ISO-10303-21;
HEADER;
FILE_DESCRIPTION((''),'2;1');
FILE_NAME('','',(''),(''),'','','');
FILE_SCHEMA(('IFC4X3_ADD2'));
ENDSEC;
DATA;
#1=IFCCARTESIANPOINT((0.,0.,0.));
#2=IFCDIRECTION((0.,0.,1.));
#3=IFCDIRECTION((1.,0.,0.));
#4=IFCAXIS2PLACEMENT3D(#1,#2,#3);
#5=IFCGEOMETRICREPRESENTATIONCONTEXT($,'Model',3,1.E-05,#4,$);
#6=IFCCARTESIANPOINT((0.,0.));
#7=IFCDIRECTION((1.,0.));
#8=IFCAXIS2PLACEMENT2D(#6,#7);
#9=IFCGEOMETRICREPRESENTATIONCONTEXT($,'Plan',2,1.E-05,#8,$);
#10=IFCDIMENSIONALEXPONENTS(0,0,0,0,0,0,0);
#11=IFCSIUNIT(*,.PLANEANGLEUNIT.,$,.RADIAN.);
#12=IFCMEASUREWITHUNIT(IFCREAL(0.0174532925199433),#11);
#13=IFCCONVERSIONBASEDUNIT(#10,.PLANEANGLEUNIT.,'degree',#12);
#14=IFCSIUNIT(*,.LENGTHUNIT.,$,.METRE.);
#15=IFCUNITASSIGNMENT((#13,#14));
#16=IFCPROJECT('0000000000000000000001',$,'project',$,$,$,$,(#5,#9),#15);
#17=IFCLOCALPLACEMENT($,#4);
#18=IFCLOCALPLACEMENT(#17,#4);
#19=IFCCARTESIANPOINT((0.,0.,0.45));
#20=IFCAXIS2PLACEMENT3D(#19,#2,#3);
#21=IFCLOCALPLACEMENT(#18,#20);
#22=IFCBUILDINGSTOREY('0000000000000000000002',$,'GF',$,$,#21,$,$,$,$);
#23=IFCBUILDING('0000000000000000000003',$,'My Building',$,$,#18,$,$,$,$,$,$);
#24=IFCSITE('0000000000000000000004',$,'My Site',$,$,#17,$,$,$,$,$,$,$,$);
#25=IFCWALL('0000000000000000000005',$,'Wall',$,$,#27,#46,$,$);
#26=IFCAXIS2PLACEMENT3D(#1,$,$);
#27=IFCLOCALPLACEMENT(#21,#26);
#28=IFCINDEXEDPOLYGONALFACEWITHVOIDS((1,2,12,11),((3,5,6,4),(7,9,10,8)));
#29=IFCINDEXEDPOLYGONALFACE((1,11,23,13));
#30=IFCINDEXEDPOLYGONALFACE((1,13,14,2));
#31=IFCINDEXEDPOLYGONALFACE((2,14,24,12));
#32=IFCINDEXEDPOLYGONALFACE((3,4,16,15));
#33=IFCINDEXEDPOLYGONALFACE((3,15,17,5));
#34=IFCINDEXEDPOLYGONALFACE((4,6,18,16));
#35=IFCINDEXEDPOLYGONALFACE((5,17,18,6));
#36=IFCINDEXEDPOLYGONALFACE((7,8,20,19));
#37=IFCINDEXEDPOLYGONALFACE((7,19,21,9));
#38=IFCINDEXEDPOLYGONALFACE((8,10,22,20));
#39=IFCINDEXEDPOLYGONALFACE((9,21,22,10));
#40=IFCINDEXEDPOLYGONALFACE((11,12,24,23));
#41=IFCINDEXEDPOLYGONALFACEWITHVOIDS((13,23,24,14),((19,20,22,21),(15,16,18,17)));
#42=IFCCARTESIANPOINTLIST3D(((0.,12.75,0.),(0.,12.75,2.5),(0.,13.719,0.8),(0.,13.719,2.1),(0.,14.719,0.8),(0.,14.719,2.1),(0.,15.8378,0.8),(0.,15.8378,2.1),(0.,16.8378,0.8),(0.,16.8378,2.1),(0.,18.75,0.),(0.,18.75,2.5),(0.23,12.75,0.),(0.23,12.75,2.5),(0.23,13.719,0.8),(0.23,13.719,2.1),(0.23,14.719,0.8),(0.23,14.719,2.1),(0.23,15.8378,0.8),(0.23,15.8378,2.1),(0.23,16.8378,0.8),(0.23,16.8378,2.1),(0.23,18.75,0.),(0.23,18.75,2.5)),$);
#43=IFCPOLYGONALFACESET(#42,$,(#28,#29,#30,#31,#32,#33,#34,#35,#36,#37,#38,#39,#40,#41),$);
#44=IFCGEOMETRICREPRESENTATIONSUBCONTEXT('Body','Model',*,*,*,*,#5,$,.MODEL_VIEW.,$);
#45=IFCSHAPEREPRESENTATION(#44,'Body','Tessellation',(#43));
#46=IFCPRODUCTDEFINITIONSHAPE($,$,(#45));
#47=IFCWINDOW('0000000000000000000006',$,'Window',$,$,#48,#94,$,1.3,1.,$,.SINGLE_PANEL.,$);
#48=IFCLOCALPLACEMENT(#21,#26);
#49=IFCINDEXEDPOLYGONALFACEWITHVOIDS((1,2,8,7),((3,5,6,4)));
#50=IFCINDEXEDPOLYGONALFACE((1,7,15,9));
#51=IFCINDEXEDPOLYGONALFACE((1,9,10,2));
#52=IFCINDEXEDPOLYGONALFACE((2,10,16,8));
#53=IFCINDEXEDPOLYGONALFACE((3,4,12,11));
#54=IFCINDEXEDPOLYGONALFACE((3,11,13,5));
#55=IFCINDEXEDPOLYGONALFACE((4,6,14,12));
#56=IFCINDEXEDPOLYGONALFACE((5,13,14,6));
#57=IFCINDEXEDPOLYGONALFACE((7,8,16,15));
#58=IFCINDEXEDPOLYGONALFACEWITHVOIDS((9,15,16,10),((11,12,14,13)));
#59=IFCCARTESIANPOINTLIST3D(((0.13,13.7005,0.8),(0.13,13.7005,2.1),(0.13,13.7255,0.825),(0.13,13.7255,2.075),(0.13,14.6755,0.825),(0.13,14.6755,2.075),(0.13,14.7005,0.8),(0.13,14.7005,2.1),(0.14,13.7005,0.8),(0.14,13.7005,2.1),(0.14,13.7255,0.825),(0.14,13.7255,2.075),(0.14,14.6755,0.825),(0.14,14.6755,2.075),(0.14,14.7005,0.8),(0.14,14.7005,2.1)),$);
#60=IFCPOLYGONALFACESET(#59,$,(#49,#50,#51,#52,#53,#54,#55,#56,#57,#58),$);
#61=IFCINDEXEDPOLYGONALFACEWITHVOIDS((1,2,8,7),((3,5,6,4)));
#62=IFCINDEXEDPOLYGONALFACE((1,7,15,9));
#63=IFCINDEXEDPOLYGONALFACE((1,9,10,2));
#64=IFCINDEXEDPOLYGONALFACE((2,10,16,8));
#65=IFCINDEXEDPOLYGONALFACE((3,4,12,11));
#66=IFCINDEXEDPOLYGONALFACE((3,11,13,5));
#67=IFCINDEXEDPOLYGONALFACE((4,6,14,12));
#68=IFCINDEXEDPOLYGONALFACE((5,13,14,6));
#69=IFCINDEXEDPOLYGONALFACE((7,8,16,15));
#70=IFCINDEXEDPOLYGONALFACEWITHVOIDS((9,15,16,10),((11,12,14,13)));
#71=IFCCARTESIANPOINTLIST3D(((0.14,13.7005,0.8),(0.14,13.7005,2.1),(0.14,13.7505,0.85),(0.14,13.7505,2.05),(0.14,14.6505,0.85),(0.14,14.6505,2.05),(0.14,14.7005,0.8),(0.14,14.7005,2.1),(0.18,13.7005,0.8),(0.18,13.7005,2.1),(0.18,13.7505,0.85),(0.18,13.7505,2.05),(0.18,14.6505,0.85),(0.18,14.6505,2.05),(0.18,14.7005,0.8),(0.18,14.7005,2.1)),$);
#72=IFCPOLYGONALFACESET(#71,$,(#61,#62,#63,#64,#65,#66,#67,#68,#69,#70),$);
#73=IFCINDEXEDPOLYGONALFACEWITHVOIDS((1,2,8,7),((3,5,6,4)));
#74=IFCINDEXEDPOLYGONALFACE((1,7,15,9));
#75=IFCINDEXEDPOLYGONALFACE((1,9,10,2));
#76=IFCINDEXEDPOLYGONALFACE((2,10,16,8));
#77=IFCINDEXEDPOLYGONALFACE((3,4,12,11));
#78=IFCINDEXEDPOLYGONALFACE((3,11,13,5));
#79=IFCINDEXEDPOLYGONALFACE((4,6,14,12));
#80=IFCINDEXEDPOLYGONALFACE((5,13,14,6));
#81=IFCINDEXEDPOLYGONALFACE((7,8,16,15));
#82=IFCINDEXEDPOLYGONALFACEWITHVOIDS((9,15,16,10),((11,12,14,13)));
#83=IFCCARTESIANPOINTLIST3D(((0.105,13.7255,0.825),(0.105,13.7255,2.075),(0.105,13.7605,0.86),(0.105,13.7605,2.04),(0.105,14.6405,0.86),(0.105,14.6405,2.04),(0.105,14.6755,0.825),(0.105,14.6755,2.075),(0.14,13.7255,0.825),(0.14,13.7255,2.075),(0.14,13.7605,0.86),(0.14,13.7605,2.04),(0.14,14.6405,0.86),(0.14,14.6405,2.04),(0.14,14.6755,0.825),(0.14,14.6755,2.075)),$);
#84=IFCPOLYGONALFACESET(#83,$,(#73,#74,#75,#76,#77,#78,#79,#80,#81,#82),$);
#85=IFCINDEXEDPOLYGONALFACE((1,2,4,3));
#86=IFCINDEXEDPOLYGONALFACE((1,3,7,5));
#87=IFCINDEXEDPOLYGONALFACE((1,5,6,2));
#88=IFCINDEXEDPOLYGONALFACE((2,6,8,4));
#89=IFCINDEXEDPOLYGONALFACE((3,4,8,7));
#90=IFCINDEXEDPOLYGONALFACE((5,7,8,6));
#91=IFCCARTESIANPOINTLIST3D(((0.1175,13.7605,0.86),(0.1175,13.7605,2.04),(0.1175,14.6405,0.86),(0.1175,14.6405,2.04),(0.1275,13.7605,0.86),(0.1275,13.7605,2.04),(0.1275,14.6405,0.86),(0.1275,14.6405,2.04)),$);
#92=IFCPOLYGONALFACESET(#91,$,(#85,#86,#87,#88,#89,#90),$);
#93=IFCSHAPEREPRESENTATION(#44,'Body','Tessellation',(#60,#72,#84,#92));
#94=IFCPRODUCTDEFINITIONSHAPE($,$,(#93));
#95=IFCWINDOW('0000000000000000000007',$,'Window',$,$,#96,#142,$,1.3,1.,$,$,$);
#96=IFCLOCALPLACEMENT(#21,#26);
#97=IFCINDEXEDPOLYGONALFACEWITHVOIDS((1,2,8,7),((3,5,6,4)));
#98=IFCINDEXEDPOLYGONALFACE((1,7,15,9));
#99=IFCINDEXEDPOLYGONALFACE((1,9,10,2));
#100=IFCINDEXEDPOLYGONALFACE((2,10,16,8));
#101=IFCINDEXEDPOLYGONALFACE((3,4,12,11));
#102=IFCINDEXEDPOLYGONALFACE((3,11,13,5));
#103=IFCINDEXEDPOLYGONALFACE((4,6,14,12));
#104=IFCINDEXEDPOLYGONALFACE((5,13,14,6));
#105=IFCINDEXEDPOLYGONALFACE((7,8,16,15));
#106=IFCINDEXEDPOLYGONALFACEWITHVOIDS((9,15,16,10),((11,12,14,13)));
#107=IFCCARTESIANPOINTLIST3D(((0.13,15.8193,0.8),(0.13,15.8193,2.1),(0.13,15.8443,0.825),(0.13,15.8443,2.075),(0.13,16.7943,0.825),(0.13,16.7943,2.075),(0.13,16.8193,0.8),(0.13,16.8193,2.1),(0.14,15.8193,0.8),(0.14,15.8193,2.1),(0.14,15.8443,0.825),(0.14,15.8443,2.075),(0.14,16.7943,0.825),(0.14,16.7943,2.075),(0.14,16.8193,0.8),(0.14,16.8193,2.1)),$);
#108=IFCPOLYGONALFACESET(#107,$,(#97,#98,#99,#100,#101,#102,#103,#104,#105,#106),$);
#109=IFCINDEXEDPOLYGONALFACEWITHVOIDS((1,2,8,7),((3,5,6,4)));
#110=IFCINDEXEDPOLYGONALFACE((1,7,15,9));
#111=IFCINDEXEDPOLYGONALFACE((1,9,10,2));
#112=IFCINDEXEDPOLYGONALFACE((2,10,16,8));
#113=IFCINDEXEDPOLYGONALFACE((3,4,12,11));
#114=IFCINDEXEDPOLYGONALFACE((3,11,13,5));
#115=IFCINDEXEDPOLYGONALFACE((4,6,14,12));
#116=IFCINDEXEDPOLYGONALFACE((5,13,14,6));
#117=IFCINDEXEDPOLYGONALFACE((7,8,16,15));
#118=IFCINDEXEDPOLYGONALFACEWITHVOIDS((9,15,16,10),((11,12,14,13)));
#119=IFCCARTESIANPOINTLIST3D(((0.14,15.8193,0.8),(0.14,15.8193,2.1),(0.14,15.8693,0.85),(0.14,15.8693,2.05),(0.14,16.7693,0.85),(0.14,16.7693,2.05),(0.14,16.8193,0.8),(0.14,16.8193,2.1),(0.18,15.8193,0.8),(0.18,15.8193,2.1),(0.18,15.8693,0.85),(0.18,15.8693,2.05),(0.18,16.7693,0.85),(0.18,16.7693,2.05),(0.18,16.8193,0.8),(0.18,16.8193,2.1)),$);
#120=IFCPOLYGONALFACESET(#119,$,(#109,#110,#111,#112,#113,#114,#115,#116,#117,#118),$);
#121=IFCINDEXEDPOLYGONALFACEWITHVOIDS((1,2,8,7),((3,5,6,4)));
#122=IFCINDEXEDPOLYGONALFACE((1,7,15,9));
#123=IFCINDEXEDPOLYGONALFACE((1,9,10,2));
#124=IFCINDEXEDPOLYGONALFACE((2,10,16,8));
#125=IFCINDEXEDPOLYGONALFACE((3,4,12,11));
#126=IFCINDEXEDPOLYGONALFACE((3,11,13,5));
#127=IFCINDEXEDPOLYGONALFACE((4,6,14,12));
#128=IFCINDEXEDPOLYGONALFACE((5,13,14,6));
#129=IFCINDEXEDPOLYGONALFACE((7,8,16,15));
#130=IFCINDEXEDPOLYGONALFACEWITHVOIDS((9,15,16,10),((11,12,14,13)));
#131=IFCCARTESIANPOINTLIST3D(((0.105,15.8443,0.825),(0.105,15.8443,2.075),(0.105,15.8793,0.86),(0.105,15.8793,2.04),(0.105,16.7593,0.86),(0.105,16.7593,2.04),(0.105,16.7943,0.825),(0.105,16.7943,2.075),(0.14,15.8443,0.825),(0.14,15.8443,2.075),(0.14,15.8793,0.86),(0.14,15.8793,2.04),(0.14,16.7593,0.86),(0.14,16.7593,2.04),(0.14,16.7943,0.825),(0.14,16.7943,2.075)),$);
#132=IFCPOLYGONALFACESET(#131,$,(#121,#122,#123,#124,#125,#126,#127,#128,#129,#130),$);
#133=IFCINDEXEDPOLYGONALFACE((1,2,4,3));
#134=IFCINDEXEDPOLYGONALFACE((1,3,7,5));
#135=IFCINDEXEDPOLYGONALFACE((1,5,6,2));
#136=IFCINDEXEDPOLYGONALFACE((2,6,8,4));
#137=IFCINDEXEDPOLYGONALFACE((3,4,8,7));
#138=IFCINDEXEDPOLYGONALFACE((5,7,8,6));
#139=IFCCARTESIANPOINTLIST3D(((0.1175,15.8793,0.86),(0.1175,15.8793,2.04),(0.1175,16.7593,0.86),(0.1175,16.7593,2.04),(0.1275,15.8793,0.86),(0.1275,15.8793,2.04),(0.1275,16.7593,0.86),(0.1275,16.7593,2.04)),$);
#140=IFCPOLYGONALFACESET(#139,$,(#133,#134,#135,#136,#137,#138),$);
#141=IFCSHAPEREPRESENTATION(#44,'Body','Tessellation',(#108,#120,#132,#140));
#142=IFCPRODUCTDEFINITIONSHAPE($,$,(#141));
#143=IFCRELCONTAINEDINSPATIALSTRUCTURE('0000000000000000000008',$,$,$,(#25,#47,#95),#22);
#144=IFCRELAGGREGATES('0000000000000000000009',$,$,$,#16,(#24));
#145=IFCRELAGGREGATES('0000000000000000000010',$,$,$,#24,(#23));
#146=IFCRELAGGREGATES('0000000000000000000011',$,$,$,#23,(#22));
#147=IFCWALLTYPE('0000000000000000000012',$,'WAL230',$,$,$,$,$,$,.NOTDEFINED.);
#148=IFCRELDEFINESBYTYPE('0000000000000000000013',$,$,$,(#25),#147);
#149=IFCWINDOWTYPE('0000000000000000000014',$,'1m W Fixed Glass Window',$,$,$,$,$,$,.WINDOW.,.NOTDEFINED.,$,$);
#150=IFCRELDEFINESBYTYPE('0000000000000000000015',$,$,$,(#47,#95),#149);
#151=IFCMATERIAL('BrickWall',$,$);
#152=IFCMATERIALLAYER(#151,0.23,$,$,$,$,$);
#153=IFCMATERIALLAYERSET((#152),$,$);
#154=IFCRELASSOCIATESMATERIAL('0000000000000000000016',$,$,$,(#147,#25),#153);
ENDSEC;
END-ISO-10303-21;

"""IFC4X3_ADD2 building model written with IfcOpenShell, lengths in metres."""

from ifc_helpers import new_model, entity, si_unit, converted_unit, frame, origin_with_axes, origin_2d_with_axis, place, context, subcontext, project, spatial, line, indexed_curve, outline, extrude, shape, source, transform, mapped, material, layer, layer_set, layer_usage, type_object, type_shapes, element, fill, save


model = new_model("IFC4X3_ADD2")

# Units and contexts
model_context = context("Model", 3, precision=1e-05, world=origin_with_axes())
plan_context = context("Plan", 2, precision=1e-05, world=origin_2d_with_axis())
body_context_1 = subcontext(model_context, "Body", "Model", "MODEL_VIEW")
body_context_2 = subcontext(plan_context, "Body", "Plan", "PLAN_VIEW")
ifc_project = project(units=[converted_unit("PLANEANGLEUNIT", "degree", entity("IfcReal", 0.0174532925199433), si_unit("PLANEANGLEUNIT", "RADIAN"), dimensions=[0, 0, 0, 0, 0, 0, 0]), si_unit("LENGTHUNIT", "METRE")], contexts=[model_context, plan_context])

# Site, building, storey
site_placement = place(None, origin_with_axes())
site = spatial("IfcSite", under=ifc_project, at=site_placement, Name="My Site")
building_placement = place(site_placement, origin_with_axes())
building = spatial("IfcBuilding", under=site, at=building_placement, Name="My Building")
storey_placement = place(building_placement, frame((0.0, 0.0, 0.45), z_axis=(0.0, 0.0, 1.0), x_axis=(1.0, 0.0, 0.0)))
storey = spatial("IfcBuildingStorey", under=building, at=storey_placement, Name="GF")

# Shared definitions
ifc_material_1 = material(Name="BrickWall")
ifc_layer_1 = layer(ifc_material_1, 0.23)
ifc_layer_set_1 = layer_set([ifc_layer_1])
wall_type_1 = type_object("IfcWallType", Name="WAL230", PredefinedType="NOTDEFINED", material=ifc_layer_set_1)
shared_shape_1 = source(origin_with_axes(), body_context_1, "Body", "SweptSolid", [
    extrude(outline(indexed_curve([(0.0, 0.0), (1.0, 0.0), (1.0, 1.3), (0.0, 1.3)], segments=[line(1, 2, 3, 4, 1)])), frame((0.0, -0.6, 0.0), z_axis=(0.0, -1.0, 0.0), x_axis=(1.0, 0.0, 0.0)), (0.0, 0.0, -1.0), 1.2),
])
window_type_1 = type_object("IfcWindowType", Name="1m W Fixed Glass Window", PartitioningType="NOTDEFINED", PredefinedType="WINDOW")
shared_shape_2 = source(origin_with_axes(), body_context_1, "Body", "SweptSolid", [
    extrude(outline(indexed_curve([(0.0, 0.0), (1.0, 0.0), (1.0, 1.3), (0.0, 1.3)], segments=[line(1, 2, 3, 4, 1)]), holes=[indexed_curve([(0.025, 0.025), (0.975, 0.025), (0.975, 1.275), (0.025, 1.275)], segments=[line(1, 2, 3, 4, 1)])]), frame((0.0, 0.09, 0.0), z_axis=(0.0, -1.0, 0.0), x_axis=(1.0, 0.0, 0.0)), (0.0, 0.0, -1.0), 0.01),
    extrude(outline(indexed_curve([(0.0, 0.0), (1.0, 0.0), (1.0, 1.3), (0.0, 1.3)], segments=[line(1, 2, 3, 4, 1)]), holes=[indexed_curve([(0.05, 0.05), (0.95, 0.05), (0.95, 1.25), (0.05, 1.25)], segments=[line(1, 2, 3, 4, 1)])]), frame((0.0, 0.05, 0.0), z_axis=(0.0, -1.0, 0.0), x_axis=(1.0, 0.0, 0.0)), (0.0, 0.0, -1.0), 0.04),
    extrude(outline(indexed_curve([(0.0, 0.0), (0.95, 0.0), (0.95, 1.25), (0.0, 1.25)], segments=[line(1, 2, 3, 4, 1)]), holes=[indexed_curve([(0.035, 0.035), (0.915, 0.035), (0.915, 1.215), (0.035, 1.215)], segments=[line(1, 2, 3, 4, 1)])]), frame((0.025, 0.09, 0.025), z_axis=(0.0, -1.0, 0.0), x_axis=(1.0, 0.0, 0.0)), (0.0, 0.0, -1.0), 0.035),
    extrude(outline(indexed_curve([(0.035, 0.035), (0.915, 0.035), (0.915, 1.215), (0.035, 1.215)], segments=[line(1, 2, 3, 4, 1)])), frame((0.025, 0.1025, 0.025), z_axis=(0.0, -1.0, 0.0), x_axis=(1.0, 0.0, 0.0)), (0.0, 0.0, -1.0), 0.01),
])
shared_shape_3 = source(origin_with_axes(), body_context_2, "Body", "Curve2D", [
    entity("IfcIndexedPolyCurve", entity("IfcCartesianPointList2D", [[0.05, 0.05], [0.95, 0.05]])),
    entity("IfcIndexedPolyCurve", entity("IfcCartesianPointList2D", [[0.0, 0.1], [0.025, 0.1], [0.025, 0.09], [0.05, 0.09], [0.05, 0.05], [0.0, 0.05]]), [entity("IfcLineIndex", [1, 2, 3, 4, 5, 6, 1])]),
    entity("IfcIndexedPolyCurve", entity("IfcCartesianPointList2D", [[1.0, 0.1], [0.975, 0.1], [0.975, 0.09], [0.95, 0.09], [0.95, 0.05], [1.0, 0.05]]), [entity("IfcLineIndex", [1, 2, 3, 4, 5, 6, 1])]),
    entity("IfcIndexedPolyCurve", entity("IfcCartesianPointList2D", [[0.025, 0.09], [0.06, 0.09], [0.06, 0.125], [0.025, 0.125]]), [entity("IfcLineIndex", [1, 2, 3, 4, 1])]),
    entity("IfcIndexedPolyCurve", entity("IfcCartesianPointList2D", [[0.975, 0.09], [0.94, 0.09], [0.94, 0.125], [0.975, 0.125]]), [entity("IfcLineIndex", [1, 2, 3, 4, 1])]),
    entity("IfcIndexedPolyCurve", entity("IfcCartesianPointList2D", [[0.06, 0.09], [0.94, 0.09]])),
    entity("IfcIndexedPolyCurve", entity("IfcCartesianPointList2D", [[0.06, 0.125], [0.94, 0.125]])),
    entity("IfcIndexedPolyCurve", entity("IfcCartesianPointList2D", [[0.06, 0.1075], [0.94, 0.1075]])),
])
type_shapes(window_type_1, [shared_shape_2, shared_shape_3])

# Wall, openings, windows
ifc_layer_usage_1 = layer_usage(ifc_layer_set_1, "AXIS2", "POSITIVE", 0.0)
wall_1_placement = place(storey_placement, frame((0.23, 12.75, 0.0), z_axis=(0.0, 0.0, 1.0), x_axis=(0.0, 1.0, 0.0)))
wall_1 = element("IfcWall", 1, at=wall_1_placement, inside=storey, type_object=wall_type_1, material=ifc_layer_usage_1, Name="Wall", context=body_context_1, shape_type="SweptSolid", body=[
    extrude(outline(indexed_curve([(0.0, 0.0), (0.0, 0.23), (6.0, 0.23), (6.0, 0.0), (0.0, 0.0)], self_intersect=False)), origin_with_axes(), (0.0, 0.0, 1.0), 2.5),
])
opening_1_placement = place(wall_1_placement, frame((0.969, 0.0, 0.8), z_axis=(0.0, 0.0, 1.0), x_axis=(1.0, 0.0, 0.0)))
opening_1 = element("IfcOpeningElement", 2, at=opening_1_placement, cuts=wall_1, PredefinedType="OPENING", context=body_context_1, shape_type="MappedRepresentation", body=[
    mapped(shared_shape_1, transform((0.0, 0.0, 0.0), x_axis=(1.0, 0.0, 0.0), y_axis=(0.0, 1.0, 0.0), z_axis=(0.0, 0.0, 1.0), scale=1.0)),
])
opening_2_placement = place(wall_1_placement, frame((3.0878, 0.0, 0.8), z_axis=(0.0, 0.0, 1.0), x_axis=(1.0, 0.0, 0.0)))
opening_2 = element("IfcOpeningElement", 3, at=opening_2_placement, cuts=wall_1, PredefinedType="OPENING", context=body_context_1, shape_type="MappedRepresentation", body=[
    mapped(shared_shape_1, transform((0.0, 0.0, 0.0), x_axis=(1.0, 0.0, 0.0), y_axis=(0.0, 1.0, 0.0), z_axis=(0.0, 0.0, 1.0), scale=1.0)),
])
window_1_placement = place(opening_1_placement, frame((-0.0184, 0.0, 0.0), z_axis=(0.0, 0.0, 1.0), x_axis=(1.0, 0.0, 0.0)))
window_1 = element("IfcWindow", 4, at=window_1_placement, inside=storey, type_object=window_type_1, Name="Window", OverallHeight=1.3, OverallWidth=1.0, PartitioningType="SINGLE_PANEL", shapes=[
    shape(body_context_1, "Body", "MappedRepresentation", [mapped(shared_shape_2, transform((0.0, 0.0, 0.0), x_axis=(1.0, 0.0, 0.0), y_axis=(0.0, 1.0, 0.0), z_axis=(0.0, 0.0, 1.0), scale=1.0))]),
    shape(body_context_2, "Body", "MappedRepresentation", [mapped(shared_shape_3, transform((0.0, 0.0, 0.0), x_axis=(1.0, 0.0, 0.0), y_axis=(0.0, 1.0, 0.0), z_axis=(0.0, 0.0, 1.0), scale=1.0))]),
])
fill(opening_1, window_1)
window_2_placement = place(opening_2_placement, frame((-0.0184, 0.0, 0.0), z_axis=(0.0, 0.0, 1.0), x_axis=(1.0, 0.0, 0.0)))
window_2 = element("IfcWindow", 5, at=window_2_placement, inside=storey, type_object=window_type_1, Name="Window", OverallHeight=1.3, OverallWidth=1.0, shapes=[
    shape(body_context_1, "Body", "MappedRepresentation", [mapped(shared_shape_2, transform((0.0, 0.0, 0.0), x_axis=(1.0, 0.0, 0.0), y_axis=(0.0, 1.0, 0.0), z_axis=(0.0, 0.0, 1.0), scale=1.0))]),
    shape(body_context_2, "Body", "MappedRepresentation", [mapped(shared_shape_3, transform((0.0, 0.0, 0.0), x_axis=(1.0, 0.0, 0.0), y_axis=(0.0, 1.0, 0.0), z_axis=(0.0, 0.0, 1.0), scale=1.0))]),
])
fill(opening_2, window_2)

save(model, "model.ifc")
